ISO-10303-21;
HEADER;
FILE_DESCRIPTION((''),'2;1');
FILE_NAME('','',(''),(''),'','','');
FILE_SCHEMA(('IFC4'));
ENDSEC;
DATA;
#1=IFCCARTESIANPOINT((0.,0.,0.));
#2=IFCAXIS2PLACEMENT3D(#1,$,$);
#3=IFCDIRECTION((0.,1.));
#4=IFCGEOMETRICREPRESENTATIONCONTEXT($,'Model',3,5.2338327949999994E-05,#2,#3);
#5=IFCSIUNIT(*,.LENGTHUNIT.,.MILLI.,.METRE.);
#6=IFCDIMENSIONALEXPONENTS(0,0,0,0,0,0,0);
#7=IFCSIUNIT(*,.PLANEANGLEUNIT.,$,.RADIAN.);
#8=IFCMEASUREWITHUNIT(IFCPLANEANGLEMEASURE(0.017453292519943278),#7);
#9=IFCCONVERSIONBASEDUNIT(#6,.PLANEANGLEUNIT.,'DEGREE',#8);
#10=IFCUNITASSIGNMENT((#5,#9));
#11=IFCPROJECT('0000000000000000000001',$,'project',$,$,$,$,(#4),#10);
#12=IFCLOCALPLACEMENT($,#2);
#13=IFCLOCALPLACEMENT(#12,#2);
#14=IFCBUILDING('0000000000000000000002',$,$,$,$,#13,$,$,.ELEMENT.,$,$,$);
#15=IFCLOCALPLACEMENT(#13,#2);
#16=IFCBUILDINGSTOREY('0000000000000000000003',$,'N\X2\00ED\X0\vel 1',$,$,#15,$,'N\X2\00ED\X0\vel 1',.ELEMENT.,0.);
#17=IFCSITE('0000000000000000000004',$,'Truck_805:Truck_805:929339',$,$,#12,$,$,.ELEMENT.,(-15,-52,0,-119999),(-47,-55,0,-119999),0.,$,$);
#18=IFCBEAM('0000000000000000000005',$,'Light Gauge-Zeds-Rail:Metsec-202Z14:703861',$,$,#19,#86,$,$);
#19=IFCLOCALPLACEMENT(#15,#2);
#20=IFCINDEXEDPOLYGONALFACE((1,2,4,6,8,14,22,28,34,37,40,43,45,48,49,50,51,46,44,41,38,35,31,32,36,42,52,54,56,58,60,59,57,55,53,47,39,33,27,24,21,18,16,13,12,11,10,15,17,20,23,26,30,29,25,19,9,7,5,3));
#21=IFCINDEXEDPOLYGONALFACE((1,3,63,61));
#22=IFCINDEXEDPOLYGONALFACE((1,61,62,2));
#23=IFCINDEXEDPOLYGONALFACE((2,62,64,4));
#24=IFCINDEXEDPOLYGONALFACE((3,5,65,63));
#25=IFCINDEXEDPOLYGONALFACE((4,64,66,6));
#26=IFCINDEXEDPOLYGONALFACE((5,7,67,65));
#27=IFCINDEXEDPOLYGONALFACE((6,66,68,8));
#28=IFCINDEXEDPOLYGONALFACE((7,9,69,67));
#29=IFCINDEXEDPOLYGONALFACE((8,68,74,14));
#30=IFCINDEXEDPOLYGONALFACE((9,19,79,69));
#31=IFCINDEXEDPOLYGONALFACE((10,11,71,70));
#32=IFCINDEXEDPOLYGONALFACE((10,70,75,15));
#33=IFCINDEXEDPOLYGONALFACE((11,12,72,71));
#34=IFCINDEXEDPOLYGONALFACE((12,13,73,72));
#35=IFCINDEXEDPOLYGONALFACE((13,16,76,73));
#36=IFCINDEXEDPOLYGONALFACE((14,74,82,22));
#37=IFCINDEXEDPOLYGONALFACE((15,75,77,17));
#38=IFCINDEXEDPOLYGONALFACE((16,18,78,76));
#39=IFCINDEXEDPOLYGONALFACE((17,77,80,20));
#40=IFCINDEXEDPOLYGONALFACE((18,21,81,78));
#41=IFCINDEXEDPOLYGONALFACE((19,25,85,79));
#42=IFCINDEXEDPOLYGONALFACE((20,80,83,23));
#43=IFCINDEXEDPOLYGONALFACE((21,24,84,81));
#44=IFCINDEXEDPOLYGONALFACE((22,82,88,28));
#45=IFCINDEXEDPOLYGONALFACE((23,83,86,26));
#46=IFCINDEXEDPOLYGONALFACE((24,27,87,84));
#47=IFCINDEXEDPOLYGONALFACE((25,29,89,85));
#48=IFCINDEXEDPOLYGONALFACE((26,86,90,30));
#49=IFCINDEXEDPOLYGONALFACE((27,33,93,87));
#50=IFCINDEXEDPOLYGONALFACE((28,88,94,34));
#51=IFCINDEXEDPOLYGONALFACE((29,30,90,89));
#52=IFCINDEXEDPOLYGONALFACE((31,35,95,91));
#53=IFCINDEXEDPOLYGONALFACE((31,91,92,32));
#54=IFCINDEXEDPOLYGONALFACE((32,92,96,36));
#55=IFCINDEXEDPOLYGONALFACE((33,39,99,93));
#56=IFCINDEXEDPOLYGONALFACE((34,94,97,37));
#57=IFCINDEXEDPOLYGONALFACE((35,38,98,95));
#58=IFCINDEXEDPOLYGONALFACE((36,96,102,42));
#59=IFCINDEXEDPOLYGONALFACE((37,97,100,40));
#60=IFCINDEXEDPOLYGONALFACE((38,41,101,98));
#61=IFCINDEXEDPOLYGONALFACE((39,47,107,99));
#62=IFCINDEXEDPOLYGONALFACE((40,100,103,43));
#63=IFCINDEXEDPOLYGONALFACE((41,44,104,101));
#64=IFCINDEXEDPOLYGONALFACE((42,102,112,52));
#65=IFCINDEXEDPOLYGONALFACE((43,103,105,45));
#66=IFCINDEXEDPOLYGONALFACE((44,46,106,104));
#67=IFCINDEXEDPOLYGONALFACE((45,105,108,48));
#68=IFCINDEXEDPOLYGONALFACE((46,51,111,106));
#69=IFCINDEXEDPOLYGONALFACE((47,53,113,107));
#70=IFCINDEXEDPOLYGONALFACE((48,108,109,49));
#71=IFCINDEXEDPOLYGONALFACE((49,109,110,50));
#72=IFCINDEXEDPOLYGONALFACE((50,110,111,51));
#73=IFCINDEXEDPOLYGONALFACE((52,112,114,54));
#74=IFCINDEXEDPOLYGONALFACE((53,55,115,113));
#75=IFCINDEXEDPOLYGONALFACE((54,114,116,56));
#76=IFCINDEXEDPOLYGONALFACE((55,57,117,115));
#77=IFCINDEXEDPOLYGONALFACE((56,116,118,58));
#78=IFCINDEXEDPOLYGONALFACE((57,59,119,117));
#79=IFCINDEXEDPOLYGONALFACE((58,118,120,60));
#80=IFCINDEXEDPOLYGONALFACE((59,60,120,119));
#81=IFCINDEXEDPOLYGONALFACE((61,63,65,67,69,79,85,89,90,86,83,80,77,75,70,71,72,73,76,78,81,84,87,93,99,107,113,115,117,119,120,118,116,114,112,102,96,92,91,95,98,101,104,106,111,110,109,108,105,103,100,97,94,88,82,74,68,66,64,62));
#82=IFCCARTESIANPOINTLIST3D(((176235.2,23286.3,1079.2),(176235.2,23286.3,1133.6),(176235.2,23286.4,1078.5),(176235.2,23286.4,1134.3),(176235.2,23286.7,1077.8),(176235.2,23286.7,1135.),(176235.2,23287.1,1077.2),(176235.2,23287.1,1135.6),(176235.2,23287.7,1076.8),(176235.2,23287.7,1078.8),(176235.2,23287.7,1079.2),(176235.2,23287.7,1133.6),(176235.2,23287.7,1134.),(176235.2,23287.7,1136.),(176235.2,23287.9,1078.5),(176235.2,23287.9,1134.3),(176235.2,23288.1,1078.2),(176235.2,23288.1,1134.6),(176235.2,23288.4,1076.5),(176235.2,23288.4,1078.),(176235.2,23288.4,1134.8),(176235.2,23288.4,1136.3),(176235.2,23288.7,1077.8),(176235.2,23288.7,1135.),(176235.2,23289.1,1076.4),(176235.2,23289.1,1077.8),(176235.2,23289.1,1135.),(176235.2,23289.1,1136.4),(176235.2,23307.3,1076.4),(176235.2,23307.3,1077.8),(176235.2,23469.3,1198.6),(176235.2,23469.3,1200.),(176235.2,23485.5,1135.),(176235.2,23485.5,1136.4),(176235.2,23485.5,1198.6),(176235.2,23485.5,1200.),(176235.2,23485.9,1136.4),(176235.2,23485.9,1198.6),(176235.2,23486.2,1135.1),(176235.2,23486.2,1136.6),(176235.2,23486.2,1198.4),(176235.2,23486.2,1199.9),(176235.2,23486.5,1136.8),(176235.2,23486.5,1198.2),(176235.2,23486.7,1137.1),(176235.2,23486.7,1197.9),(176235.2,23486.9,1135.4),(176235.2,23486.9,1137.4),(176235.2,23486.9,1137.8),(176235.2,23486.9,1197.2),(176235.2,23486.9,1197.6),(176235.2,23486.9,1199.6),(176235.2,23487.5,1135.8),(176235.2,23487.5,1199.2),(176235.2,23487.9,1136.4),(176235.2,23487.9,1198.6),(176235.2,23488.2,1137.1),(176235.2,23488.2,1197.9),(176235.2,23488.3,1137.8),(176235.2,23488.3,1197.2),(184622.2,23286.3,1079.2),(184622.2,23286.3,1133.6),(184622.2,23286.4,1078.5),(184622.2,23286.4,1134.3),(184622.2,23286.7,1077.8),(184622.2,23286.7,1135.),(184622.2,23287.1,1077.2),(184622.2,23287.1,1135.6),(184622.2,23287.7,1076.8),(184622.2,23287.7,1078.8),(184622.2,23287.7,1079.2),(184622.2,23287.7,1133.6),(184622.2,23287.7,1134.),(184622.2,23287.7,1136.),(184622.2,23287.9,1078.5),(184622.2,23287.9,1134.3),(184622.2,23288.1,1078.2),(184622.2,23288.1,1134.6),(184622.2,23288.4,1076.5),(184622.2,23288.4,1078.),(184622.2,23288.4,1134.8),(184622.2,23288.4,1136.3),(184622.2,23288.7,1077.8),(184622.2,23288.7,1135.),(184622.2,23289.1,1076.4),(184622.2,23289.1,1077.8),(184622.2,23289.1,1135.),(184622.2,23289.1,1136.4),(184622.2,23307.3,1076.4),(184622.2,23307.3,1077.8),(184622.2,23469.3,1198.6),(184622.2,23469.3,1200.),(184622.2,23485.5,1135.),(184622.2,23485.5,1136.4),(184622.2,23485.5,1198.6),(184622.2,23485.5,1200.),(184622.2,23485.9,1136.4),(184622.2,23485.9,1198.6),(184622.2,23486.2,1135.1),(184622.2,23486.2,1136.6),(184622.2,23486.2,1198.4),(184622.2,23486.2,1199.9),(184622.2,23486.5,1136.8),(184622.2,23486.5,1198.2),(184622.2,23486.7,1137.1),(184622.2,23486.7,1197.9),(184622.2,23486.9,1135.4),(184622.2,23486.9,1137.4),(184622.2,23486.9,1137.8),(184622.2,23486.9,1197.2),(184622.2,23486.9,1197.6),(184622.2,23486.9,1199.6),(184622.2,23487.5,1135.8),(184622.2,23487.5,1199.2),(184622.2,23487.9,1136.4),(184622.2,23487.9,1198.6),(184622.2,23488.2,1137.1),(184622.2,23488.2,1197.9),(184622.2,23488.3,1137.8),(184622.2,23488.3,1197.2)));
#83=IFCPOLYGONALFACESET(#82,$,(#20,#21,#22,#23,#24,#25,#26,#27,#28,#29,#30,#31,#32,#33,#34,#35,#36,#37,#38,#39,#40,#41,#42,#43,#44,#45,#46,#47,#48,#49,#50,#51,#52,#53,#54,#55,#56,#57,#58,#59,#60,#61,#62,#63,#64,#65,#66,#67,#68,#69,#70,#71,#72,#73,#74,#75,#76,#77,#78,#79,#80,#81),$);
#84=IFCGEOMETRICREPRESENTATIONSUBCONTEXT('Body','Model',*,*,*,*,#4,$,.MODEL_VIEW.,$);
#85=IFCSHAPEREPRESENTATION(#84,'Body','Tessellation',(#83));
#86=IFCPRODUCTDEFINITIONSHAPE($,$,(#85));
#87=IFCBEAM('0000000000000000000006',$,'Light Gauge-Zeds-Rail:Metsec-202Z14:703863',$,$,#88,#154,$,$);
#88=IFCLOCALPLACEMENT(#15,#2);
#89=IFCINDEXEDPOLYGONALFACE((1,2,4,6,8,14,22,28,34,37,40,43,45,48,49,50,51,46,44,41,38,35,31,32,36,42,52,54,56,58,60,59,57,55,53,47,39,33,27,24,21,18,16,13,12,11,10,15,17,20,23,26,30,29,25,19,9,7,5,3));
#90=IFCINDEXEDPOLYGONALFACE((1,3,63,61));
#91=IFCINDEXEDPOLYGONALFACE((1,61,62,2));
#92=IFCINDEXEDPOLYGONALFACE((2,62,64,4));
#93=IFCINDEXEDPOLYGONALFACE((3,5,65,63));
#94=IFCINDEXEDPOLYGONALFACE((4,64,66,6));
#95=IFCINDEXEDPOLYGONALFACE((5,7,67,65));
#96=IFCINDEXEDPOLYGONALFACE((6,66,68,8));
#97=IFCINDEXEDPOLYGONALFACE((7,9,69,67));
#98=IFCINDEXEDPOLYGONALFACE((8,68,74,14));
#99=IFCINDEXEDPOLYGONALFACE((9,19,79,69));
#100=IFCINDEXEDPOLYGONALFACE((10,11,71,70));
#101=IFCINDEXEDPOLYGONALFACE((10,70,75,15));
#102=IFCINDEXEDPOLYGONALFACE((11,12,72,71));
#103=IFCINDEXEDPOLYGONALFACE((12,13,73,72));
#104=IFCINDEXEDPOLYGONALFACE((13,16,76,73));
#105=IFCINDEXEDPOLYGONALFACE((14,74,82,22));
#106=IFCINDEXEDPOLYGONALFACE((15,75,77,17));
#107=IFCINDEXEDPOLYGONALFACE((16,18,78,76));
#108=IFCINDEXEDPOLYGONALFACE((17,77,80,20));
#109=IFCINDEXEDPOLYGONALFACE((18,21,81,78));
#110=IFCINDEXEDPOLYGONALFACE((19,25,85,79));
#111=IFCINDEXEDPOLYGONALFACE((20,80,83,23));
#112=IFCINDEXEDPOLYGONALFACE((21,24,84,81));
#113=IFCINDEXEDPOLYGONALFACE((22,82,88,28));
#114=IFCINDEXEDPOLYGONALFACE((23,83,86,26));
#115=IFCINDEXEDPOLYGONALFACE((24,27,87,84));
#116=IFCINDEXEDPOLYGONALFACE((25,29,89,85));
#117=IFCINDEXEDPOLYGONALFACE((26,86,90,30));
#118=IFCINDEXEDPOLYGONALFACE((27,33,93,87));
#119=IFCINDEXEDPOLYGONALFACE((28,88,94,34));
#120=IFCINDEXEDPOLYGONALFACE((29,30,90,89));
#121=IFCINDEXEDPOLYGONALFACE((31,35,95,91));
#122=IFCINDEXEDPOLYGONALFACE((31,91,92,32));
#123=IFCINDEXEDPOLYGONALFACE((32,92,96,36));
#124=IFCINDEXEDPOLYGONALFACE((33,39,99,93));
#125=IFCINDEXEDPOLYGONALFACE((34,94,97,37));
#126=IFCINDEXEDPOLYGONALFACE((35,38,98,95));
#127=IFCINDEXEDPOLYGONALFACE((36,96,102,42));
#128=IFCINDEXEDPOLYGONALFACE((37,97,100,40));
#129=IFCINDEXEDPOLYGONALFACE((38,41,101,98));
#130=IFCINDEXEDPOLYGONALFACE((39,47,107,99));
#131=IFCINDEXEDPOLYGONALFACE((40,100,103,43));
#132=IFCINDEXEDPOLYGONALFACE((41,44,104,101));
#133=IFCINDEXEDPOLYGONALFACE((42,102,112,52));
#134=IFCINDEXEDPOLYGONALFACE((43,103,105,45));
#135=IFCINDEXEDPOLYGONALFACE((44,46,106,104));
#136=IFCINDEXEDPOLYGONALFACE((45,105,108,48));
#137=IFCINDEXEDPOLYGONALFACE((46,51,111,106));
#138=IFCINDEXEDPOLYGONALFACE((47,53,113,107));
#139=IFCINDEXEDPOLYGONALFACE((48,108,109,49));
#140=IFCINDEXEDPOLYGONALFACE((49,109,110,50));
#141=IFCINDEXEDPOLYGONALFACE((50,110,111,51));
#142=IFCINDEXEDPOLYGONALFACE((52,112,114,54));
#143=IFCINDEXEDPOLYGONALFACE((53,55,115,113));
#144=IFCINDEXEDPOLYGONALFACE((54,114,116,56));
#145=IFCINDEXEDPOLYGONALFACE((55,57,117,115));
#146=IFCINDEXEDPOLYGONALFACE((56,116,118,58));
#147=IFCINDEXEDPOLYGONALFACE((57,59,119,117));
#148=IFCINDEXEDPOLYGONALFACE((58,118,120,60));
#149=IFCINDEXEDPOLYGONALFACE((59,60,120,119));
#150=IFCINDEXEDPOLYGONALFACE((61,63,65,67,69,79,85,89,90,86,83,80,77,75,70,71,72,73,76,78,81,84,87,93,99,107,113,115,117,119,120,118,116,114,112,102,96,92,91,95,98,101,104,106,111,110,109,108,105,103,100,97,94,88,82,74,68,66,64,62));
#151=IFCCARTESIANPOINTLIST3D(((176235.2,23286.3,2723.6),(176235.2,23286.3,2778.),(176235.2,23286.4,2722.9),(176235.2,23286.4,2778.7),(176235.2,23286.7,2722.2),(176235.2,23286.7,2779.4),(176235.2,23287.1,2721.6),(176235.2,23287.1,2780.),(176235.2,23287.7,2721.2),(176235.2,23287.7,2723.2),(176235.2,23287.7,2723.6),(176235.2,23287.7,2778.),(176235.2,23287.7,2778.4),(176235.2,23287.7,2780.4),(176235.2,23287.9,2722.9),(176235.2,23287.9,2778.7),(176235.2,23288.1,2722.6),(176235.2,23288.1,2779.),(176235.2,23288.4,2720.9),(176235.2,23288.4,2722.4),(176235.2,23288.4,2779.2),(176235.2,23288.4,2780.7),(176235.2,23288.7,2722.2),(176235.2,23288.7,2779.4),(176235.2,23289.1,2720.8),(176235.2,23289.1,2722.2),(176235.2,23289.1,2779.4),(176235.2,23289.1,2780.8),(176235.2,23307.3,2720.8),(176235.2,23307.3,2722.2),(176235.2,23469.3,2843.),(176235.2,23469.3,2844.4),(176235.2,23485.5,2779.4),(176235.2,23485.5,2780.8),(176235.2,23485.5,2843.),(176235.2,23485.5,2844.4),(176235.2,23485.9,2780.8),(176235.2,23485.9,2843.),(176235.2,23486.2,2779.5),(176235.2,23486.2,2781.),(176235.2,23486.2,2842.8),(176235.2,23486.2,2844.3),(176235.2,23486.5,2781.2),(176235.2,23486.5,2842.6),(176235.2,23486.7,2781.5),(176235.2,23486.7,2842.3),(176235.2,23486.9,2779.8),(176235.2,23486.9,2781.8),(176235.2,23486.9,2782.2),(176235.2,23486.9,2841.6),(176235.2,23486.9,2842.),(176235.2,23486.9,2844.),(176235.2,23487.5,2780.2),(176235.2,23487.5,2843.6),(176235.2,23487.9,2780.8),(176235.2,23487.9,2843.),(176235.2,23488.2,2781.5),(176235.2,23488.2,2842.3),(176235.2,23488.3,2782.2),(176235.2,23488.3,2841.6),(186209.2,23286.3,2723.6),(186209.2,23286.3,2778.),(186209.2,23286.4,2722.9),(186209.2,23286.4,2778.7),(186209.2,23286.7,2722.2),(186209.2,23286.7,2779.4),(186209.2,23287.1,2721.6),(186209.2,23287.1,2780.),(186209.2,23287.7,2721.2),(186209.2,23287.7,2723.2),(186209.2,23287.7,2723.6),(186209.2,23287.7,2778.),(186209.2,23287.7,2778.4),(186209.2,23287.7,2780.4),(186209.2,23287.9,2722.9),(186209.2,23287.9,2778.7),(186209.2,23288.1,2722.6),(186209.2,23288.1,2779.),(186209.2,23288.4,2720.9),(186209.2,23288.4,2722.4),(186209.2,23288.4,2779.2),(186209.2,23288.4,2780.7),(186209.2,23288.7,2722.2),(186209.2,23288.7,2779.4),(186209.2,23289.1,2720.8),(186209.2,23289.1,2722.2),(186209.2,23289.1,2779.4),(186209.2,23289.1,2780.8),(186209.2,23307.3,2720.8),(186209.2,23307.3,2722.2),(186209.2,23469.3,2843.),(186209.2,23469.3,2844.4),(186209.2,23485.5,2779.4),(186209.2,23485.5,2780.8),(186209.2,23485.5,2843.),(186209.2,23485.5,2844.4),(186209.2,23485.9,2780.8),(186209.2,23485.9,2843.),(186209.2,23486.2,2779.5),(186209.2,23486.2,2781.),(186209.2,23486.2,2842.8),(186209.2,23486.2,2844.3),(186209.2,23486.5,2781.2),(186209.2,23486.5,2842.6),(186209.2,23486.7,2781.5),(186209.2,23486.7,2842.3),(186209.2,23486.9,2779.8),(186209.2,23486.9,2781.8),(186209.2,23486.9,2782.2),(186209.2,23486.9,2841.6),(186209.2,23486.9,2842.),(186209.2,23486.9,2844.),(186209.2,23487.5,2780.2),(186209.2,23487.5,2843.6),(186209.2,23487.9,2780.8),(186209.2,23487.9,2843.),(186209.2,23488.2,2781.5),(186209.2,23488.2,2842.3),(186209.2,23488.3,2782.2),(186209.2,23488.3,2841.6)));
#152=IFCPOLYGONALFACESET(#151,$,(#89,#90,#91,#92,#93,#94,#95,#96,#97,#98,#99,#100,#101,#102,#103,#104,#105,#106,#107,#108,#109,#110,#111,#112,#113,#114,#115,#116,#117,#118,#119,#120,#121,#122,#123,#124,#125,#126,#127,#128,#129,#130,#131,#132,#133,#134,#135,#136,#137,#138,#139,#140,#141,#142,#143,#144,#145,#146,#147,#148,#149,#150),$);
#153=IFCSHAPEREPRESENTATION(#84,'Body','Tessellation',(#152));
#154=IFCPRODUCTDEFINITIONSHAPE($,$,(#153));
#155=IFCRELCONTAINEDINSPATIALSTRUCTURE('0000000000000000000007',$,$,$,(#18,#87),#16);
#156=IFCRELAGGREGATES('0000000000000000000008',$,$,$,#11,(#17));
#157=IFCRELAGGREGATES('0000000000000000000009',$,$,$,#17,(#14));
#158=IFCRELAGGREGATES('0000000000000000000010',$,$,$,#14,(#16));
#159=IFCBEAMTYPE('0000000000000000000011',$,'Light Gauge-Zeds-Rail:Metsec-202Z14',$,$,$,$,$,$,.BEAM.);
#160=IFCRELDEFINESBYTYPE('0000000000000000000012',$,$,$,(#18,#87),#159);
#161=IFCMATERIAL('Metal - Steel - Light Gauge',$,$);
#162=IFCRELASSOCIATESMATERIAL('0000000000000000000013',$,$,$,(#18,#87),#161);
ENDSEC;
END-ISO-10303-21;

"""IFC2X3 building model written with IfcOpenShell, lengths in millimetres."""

from ifc_helpers import new_model, entity, si_unit, converted_unit, direction, frame, frame_2d, origin, place, context, subcontext, project, spatial, polyline, circle_curve, parameter, trimmed, segment, composite_curve, outline, extrude, material, type_object, element, save


model = new_model("IFC2X3")

# Units and contexts
model_context = context("Model", 3, precision=5.2338327949999994e-05, world=origin(), true_north=direction((0.0, 1.0)))
body_context = subcontext(model_context, "Body", "Model", "MODEL_VIEW")
ifc_project = project(units=[si_unit("LENGTHUNIT", "METRE", prefix="MILLI"), converted_unit("PLANEANGLEUNIT", "DEGREE", entity("IfcPlaneAngleMeasure", 0.017453292519943278), si_unit("PLANEANGLEUNIT", "RADIAN"), dimensions=[0, 0, 0, 0, 0, 0, 0])], contexts=[model_context])

# Site, building, storey
site_placement = place(None, origin())
site = spatial("IfcSite", under=ifc_project, at=site_placement, Name="Truck_805:Truck_805:929339", CompositionType="ELEMENT", RefLatitude=(-15, -52, 0, -119999), RefLongitude=(-47, -55, 0, -119999), RefElevation=0.0)
building_placement = place(site_placement, origin())
building = spatial("IfcBuilding", under=site, at=building_placement, CompositionType="ELEMENT")
storey_placement = place(building_placement, origin())
storey = spatial("IfcBuildingStorey", under=building, at=storey_placement, Name="Nível 1", LongName="Nível 1", CompositionType="ELEMENT", Elevation=0.0)

# Beams
ifc_material_1 = material(Name="Metal - Steel - Light Gauge")
beam_type_1 = type_object("IfcBeamType", Name="Light Gauge-Zeds-Rail:Metsec-202Z14", PredefinedType="BEAM")
beam_1_placement = place(storey_placement, frame((176222.2, 23388.2, 1200.0)))
element("IfcBeam", 1, at=beam_1_placement, inside=storey, type_object=beam_type_1, material=ifc_material_1, Name="Light Gauge-Zeds-Rail:Metsec-202Z14:703861", context=body_context, shape_type="SweptSolid", body=[
    extrude(outline(composite_curve([segment(polyline([(3.6, -101.2), (58.0, -101.2)]), True, "CONTINUOUS"), segment(trimmed(circle_curve(frame_2d((58.0, -98.4), x_axis=(0.0, -1.0)), 2.8), [parameter(0.0)], [parameter(90.0)], True, "PARAMETER"), True, "CONTINUOUS"), segment(polyline([(60.8, -98.4), (60.8, -80.2)]), True, "CONTINUOUS"), segment(polyline([(60.8, -80.2), (59.4, -80.2)]), True, "CONTINUOUS"), segment(polyline([(59.4, -80.2), (59.4, -98.4)]), True, "CONTINUOUS"), segment(trimmed(circle_curve(frame_2d((58.0, -98.4), x_axis=(1.0, 0.0)), 1.4), [parameter(270.0)], [parameter(0.0)], True, "PARAMETER"), False, "CONTINUOUS"), segment(polyline([(58.0, -99.8), (3.6, -99.8)]), True, "CONTINUOUS"), segment(trimmed(circle_curve(frame_2d((3.6, -98.4), x_axis=(0.0, -1.0)), 1.4), [parameter(270.0)], [parameter(0.0)], True, "PARAMETER"), False, "CONTINUOUS"), segment(polyline([(2.2, -98.4), (2.2, 98.0)]), True, "CONTINUOUS"), segment(trimmed(circle_curve(frame_2d((-0.6, 98.0), x_axis=(1.0, 0.0)), 2.8), [parameter(0.0)], [parameter(90.0)], True, "PARAMETER"), True, "CONTINUOUS"), segment(polyline([(-0.6, 100.8), (-60.0, 100.8)]), True, "CONTINUOUS"), segment(trimmed(circle_curve(frame_2d((-60.0, 98.0), x_axis=(0.0, 1.0)), 2.8), [parameter(0.0)], [parameter(90.0)], True, "PARAMETER"), True, "CONTINUOUS"), segment(polyline([(-62.8, 98.0), (-62.8, 81.8)]), True, "CONTINUOUS"), segment(polyline([(-62.8, 81.8), (-61.4, 81.8)]), True, "CONTINUOUS"), segment(polyline([(-61.4, 81.8), (-61.4, 98.0)]), True, "CONTINUOUS"), segment(trimmed(circle_curve(frame_2d((-60.0, 98.0), x_axis=(-1.0, 0.0)), 1.4), [parameter(270.0)], [parameter(0.0)], True, "PARAMETER"), False, "CONTINUOUS"), segment(polyline([(-60.0, 99.4), (-0.6, 99.4)]), True, "CONTINUOUS"), segment(trimmed(circle_curve(frame_2d((-0.6, 98.0), x_axis=(0.0, 1.0)), 1.4), [parameter(270.0)], [parameter(0.0)], True, "PARAMETER"), False, "CONTINUOUS"), segment(polyline([(0.8, 98.0), (0.8, -98.4)]), True, "CONTINUOUS"), segment(trimmed(circle_curve(frame_2d((3.6, -98.4), x_axis=(-1.0, 0.0)), 2.8), [parameter(0.0)], [parameter(90.0)], True, "PARAMETER"), True, "CONTINUOUS")], self_intersect=False)), frame((13.0, -0.7, -62.8), z_axis=(1.0, 0.0, 0.0), x_axis=(0.0, 0.0, -1.0)), (0.0, 0.0, 1.0), 8387.0),
])
beam_2_placement = place(storey_placement, frame((176222.2, 23388.2, 2844.4)))
element("IfcBeam", 2, at=beam_2_placement, inside=storey, type_object=beam_type_1, material=ifc_material_1, Name="Light Gauge-Zeds-Rail:Metsec-202Z14:703863", context=body_context, shape_type="SweptSolid", body=[
    extrude(outline(composite_curve([segment(polyline([(3.6, -101.2), (58.0, -101.2)]), True, "CONTINUOUS"), segment(trimmed(circle_curve(frame_2d((58.0, -98.4), x_axis=(0.0, -1.0)), 2.8), [parameter(0.0)], [parameter(90.0)], True, "PARAMETER"), True, "CONTINUOUS"), segment(polyline([(60.8, -98.4), (60.8, -80.2)]), True, "CONTINUOUS"), segment(polyline([(60.8, -80.2), (59.4, -80.2)]), True, "CONTINUOUS"), segment(polyline([(59.4, -80.2), (59.4, -98.4)]), True, "CONTINUOUS"), segment(trimmed(circle_curve(frame_2d((58.0, -98.4), x_axis=(1.0, 0.0)), 1.4), [parameter(270.0)], [parameter(0.0)], True, "PARAMETER"), False, "CONTINUOUS"), segment(polyline([(58.0, -99.8), (3.6, -99.8)]), True, "CONTINUOUS"), segment(trimmed(circle_curve(frame_2d((3.6, -98.4), x_axis=(0.0, -1.0)), 1.4), [parameter(270.0)], [parameter(0.0)], True, "PARAMETER"), False, "CONTINUOUS"), segment(polyline([(2.2, -98.4), (2.2, 98.0)]), True, "CONTINUOUS"), segment(trimmed(circle_curve(frame_2d((-0.6, 98.0), x_axis=(1.0, 0.0)), 2.8), [parameter(0.0)], [parameter(90.0)], True, "PARAMETER"), True, "CONTINUOUS"), segment(polyline([(-0.6, 100.8), (-60.0, 100.8)]), True, "CONTINUOUS"), segment(trimmed(circle_curve(frame_2d((-60.0, 98.0), x_axis=(0.0, 1.0)), 2.8), [parameter(0.0)], [parameter(90.0)], True, "PARAMETER"), True, "CONTINUOUS"), segment(polyline([(-62.8, 98.0), (-62.8, 81.8)]), True, "CONTINUOUS"), segment(polyline([(-62.8, 81.8), (-61.4, 81.8)]), True, "CONTINUOUS"), segment(polyline([(-61.4, 81.8), (-61.4, 98.0)]), True, "CONTINUOUS"), segment(trimmed(circle_curve(frame_2d((-60.0, 98.0), x_axis=(-1.0, 0.0)), 1.4), [parameter(270.0)], [parameter(0.0)], True, "PARAMETER"), False, "CONTINUOUS"), segment(polyline([(-60.0, 99.4), (-0.6, 99.4)]), True, "CONTINUOUS"), segment(trimmed(circle_curve(frame_2d((-0.6, 98.0), x_axis=(0.0, 1.0)), 1.4), [parameter(270.0)], [parameter(0.0)], True, "PARAMETER"), False, "CONTINUOUS"), segment(polyline([(0.8, 98.0), (0.8, -98.4)]), True, "CONTINUOUS"), segment(trimmed(circle_curve(frame_2d((3.6, -98.4), x_axis=(-1.0, 0.0)), 2.8), [parameter(0.0)], [parameter(90.0)], True, "PARAMETER"), True, "CONTINUOUS")], self_intersect=False)), frame((13.0, -0.7, -62.8), z_axis=(1.0, 0.0, 0.0), x_axis=(0.0, 0.0, -1.0)), (0.0, 0.0, 1.0), 9974.0),
])

save(model, "model.ifc")
